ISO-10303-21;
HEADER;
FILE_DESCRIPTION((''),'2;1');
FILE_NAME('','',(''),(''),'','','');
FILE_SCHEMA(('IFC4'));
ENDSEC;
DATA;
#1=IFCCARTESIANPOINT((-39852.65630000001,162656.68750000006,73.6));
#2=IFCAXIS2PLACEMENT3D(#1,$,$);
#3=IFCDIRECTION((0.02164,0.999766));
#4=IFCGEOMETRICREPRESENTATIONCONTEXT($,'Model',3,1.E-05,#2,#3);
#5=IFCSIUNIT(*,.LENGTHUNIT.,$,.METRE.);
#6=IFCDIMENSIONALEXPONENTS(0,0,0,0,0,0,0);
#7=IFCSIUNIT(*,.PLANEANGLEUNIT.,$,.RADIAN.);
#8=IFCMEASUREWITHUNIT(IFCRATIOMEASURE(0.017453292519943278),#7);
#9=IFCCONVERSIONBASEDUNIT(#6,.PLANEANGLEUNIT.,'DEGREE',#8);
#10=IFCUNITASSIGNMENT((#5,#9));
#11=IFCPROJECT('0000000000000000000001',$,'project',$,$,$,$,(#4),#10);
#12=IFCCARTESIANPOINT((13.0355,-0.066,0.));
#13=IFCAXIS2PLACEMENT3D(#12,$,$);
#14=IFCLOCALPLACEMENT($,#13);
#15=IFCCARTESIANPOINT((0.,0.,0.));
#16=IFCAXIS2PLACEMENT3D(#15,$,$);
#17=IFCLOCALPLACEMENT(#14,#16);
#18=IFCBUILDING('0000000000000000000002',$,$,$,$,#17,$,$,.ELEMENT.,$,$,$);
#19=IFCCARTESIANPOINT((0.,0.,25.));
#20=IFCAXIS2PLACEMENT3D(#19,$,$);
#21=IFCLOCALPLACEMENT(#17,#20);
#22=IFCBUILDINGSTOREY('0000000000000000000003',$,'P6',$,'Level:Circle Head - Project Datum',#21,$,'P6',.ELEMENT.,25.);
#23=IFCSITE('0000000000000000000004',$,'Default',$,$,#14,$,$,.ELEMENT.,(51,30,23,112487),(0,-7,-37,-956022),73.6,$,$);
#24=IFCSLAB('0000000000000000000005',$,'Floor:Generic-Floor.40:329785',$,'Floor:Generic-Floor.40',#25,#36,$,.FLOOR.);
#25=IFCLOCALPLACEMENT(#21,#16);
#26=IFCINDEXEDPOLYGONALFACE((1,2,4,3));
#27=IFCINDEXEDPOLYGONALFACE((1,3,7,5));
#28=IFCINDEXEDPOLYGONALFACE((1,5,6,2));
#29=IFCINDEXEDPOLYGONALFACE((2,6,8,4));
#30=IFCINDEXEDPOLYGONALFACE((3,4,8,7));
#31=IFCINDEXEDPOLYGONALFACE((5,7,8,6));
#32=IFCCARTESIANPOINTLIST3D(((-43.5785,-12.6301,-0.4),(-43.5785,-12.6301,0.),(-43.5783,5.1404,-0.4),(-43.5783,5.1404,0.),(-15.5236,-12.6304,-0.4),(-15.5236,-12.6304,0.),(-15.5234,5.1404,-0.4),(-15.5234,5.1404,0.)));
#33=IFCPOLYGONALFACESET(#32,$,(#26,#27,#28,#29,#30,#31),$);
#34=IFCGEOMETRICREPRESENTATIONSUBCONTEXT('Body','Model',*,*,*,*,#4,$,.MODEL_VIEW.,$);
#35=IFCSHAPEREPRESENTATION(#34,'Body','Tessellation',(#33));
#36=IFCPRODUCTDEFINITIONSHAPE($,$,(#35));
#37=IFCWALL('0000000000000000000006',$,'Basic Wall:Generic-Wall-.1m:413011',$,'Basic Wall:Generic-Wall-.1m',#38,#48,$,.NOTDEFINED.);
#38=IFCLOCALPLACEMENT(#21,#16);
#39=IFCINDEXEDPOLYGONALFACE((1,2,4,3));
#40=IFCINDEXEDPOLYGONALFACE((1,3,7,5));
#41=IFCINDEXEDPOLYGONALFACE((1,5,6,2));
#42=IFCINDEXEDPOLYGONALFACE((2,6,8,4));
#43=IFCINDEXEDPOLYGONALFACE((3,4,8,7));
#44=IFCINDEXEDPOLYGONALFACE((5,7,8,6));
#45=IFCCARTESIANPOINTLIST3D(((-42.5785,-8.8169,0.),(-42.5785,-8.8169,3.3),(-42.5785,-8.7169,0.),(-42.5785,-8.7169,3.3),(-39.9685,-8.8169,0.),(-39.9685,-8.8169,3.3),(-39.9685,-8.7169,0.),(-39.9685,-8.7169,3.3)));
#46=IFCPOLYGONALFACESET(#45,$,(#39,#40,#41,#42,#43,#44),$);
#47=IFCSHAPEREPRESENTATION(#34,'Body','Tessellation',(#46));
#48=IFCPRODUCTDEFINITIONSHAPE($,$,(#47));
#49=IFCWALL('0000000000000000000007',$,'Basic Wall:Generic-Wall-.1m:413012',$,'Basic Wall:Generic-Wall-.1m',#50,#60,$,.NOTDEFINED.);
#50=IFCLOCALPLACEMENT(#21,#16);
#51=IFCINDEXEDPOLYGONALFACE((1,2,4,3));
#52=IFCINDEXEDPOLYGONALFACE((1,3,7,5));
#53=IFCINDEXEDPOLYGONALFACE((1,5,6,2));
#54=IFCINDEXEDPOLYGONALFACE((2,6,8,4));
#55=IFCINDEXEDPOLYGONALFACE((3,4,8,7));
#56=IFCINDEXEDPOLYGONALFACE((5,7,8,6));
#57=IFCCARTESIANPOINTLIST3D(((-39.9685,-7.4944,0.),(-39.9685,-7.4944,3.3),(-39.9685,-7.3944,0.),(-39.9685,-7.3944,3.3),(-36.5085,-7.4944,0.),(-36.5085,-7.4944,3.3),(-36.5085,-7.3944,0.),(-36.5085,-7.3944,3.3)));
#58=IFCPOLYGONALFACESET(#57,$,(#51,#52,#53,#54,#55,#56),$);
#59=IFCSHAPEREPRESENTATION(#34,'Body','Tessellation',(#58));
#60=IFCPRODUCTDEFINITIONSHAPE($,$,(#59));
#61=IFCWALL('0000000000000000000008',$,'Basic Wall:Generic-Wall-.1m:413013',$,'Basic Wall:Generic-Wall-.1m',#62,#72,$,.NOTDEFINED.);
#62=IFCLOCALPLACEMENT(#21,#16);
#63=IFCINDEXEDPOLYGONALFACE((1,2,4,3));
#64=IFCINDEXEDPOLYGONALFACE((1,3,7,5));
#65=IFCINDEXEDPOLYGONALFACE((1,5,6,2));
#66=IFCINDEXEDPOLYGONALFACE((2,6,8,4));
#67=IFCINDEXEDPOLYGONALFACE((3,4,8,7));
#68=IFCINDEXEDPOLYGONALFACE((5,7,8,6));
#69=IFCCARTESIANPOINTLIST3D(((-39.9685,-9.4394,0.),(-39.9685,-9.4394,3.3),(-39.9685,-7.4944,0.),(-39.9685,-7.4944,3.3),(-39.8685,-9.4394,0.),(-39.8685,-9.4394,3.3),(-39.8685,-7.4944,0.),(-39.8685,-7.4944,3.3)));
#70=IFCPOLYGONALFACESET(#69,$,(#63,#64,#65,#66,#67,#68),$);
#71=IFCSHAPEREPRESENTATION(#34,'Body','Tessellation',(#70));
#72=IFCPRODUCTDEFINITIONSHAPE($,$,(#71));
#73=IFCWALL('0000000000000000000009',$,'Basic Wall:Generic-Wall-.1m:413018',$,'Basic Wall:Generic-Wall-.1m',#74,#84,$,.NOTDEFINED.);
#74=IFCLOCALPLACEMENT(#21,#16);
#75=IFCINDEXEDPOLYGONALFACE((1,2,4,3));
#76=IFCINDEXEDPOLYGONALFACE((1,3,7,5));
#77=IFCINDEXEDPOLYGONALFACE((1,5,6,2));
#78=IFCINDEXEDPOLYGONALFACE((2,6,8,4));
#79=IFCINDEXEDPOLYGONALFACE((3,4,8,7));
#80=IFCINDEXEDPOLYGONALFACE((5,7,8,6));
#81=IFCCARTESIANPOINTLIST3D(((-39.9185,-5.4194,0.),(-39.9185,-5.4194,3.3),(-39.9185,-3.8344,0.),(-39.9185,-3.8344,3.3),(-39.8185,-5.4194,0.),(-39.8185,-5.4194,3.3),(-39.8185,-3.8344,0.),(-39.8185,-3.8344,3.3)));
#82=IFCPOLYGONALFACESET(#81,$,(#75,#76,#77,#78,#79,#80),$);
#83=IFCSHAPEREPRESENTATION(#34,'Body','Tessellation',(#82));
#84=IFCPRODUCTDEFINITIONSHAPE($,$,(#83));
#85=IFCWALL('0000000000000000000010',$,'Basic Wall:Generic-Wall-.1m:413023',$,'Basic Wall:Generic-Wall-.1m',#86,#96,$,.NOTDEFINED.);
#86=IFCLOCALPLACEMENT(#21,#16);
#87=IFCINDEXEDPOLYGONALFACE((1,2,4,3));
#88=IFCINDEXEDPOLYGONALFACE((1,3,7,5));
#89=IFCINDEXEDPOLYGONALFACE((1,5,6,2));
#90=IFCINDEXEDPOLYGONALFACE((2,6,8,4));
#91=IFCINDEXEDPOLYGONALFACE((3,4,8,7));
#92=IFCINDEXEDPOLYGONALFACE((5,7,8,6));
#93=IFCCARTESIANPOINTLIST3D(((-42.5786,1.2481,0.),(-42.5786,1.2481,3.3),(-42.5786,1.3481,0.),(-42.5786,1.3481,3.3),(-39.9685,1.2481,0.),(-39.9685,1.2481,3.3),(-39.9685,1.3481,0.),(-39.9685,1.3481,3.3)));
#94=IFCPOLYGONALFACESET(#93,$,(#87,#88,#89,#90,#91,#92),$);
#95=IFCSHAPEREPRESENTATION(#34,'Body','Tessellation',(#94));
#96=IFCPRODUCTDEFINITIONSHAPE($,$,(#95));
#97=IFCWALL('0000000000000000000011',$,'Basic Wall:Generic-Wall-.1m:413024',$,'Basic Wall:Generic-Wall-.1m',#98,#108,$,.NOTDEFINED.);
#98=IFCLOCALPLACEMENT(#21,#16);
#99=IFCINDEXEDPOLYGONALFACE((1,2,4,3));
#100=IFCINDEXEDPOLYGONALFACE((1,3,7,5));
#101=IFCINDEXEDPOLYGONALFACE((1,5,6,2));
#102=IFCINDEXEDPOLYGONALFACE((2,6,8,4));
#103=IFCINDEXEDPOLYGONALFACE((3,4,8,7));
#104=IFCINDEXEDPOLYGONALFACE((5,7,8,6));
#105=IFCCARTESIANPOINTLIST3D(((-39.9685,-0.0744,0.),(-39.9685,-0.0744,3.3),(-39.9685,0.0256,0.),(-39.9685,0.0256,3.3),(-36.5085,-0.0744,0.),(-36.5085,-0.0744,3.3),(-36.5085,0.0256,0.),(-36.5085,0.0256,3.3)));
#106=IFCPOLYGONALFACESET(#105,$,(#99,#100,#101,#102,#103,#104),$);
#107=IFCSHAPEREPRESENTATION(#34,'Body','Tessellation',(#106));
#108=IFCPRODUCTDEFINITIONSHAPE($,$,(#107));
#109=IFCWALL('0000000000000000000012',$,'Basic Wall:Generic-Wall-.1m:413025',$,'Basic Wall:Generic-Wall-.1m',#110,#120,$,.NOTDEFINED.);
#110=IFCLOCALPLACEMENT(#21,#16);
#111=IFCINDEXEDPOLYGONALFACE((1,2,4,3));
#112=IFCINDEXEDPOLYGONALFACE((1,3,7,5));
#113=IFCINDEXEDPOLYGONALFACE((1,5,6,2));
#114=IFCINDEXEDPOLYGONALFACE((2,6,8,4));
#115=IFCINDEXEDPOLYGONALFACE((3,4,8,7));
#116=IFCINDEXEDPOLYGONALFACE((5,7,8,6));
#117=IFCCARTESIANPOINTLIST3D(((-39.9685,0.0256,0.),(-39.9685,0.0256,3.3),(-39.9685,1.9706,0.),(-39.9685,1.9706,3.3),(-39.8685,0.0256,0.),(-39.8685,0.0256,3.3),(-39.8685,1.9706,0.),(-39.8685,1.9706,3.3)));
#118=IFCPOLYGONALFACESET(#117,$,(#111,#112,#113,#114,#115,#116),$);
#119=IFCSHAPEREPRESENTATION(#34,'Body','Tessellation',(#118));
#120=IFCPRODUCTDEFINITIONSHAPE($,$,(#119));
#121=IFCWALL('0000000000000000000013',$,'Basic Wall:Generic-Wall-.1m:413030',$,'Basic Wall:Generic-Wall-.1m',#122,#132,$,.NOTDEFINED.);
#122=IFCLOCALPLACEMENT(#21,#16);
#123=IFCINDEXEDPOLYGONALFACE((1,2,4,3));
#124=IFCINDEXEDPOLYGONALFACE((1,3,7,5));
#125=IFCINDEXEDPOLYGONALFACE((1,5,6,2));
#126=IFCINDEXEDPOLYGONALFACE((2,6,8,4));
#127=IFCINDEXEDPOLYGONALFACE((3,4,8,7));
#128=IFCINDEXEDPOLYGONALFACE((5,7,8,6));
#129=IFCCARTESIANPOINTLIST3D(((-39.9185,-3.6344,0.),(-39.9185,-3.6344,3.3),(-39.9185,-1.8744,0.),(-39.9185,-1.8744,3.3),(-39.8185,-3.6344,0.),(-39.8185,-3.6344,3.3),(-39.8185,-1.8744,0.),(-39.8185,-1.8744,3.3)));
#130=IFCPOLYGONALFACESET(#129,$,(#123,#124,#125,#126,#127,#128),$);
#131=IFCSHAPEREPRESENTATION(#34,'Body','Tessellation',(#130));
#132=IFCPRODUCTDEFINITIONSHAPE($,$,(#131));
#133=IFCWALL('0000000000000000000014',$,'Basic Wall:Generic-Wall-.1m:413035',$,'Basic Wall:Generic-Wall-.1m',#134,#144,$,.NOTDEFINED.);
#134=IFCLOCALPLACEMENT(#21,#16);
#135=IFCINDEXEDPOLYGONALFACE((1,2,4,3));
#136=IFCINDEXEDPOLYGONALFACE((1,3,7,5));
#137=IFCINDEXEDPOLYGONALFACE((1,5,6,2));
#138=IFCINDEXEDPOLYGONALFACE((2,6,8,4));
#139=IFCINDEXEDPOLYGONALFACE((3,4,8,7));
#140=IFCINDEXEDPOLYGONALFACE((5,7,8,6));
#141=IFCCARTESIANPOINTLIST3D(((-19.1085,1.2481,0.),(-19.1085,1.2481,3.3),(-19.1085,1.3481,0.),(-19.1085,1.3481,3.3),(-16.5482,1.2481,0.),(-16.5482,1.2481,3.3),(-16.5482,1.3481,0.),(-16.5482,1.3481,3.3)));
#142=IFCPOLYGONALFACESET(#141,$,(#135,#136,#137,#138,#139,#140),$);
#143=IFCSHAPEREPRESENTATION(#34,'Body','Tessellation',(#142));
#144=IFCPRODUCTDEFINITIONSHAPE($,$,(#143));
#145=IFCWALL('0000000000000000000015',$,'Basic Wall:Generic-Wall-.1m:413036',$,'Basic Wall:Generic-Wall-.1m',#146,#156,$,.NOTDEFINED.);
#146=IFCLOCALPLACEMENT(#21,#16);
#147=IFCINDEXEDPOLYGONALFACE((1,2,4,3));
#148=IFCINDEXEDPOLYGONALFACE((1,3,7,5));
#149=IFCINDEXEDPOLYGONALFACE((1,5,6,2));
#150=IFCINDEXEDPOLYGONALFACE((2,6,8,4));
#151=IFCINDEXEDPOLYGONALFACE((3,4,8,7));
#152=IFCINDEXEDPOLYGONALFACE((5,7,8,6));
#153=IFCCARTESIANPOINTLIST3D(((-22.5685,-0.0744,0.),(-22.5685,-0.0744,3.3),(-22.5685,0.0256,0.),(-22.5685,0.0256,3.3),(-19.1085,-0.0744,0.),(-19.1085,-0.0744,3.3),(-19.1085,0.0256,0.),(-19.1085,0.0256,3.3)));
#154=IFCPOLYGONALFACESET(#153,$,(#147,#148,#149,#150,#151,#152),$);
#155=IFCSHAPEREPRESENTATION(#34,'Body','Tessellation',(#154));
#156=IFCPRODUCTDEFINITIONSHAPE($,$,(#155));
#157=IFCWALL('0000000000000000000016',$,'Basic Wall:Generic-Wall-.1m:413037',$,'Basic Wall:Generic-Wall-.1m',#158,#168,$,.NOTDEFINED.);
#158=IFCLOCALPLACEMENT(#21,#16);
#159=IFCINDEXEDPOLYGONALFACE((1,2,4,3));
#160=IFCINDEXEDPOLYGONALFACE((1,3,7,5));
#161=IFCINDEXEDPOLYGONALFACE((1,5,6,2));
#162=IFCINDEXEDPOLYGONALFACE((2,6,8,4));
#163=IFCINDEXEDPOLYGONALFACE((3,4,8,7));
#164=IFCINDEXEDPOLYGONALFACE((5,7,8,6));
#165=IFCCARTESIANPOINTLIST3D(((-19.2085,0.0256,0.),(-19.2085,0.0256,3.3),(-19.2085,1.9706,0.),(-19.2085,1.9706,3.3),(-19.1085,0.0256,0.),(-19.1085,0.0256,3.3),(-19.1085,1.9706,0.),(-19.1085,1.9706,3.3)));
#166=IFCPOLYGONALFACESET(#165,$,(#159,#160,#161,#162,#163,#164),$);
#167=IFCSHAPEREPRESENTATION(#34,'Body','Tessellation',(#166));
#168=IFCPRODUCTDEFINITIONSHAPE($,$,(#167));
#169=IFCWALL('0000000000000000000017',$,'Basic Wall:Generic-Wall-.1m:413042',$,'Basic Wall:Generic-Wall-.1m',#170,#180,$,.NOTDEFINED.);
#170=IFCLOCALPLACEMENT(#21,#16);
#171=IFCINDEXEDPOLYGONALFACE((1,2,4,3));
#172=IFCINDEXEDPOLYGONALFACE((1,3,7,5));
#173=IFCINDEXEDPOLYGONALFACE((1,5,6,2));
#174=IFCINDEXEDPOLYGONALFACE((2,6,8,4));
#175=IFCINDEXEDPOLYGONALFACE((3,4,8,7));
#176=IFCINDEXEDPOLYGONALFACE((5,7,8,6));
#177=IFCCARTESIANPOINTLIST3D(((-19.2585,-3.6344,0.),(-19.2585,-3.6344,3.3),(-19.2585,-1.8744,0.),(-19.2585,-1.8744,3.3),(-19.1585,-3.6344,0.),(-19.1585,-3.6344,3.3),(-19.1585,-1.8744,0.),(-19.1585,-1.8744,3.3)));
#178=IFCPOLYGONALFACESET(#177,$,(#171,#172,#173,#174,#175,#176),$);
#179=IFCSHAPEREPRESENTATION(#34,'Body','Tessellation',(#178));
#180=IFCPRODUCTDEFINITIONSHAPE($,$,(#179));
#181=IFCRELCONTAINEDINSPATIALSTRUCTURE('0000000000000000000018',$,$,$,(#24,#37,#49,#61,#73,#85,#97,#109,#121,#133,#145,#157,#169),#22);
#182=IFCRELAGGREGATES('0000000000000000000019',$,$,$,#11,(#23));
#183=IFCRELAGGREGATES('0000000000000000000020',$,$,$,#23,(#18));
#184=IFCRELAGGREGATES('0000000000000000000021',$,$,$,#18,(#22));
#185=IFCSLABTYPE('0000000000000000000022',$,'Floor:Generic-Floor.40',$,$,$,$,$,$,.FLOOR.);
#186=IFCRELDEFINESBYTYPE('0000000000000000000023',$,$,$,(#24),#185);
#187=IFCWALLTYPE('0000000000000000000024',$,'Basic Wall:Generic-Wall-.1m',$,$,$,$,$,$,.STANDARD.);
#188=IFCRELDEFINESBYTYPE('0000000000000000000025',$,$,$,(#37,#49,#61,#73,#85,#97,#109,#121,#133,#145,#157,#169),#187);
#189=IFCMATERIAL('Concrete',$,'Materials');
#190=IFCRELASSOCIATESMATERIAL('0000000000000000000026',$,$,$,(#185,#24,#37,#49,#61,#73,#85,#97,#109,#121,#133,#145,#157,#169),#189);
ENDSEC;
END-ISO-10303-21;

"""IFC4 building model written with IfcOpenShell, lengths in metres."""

from ifc_helpers import new_model, entity, si_unit, converted_unit, direction, frame, origin, place, context, subcontext, project, spatial, indexed_curve, outline, extrude, material, type_object, element, save


model = new_model("IFC4")

# Units and contexts
model_context = context("Model", 3, precision=1e-05, world=frame((-39852.65630000001, 162656.68750000006, 73.6)), true_north=direction((0.02164, 0.999766)))
body_context = subcontext(model_context, "Body", "Model", "MODEL_VIEW")
ifc_project = project(units=[si_unit("LENGTHUNIT", "METRE"), converted_unit("PLANEANGLEUNIT", "DEGREE", entity("IfcRatioMeasure", 0.017453292519943278), si_unit("PLANEANGLEUNIT", "RADIAN"), dimensions=[0, 0, 0, 0, 0, 0, 0])], contexts=[model_context])

# Site, building, storey
site_placement = place(None, frame((13.0355, -0.066, 0.0)))
site = spatial("IfcSite", under=ifc_project, at=site_placement, Name="Default", CompositionType="ELEMENT", RefLatitude=(51, 30, 23, 112487), RefLongitude=(0, -7, -37, -956022), RefElevation=73.6)
building_placement = place(site_placement, origin())
building = spatial("IfcBuilding", under=site, at=building_placement, CompositionType="ELEMENT")
storey_placement = place(building_placement, frame((0.0, 0.0, 25.0)))
storey = spatial("IfcBuildingStorey", under=building, at=storey_placement, Name="P6", ObjectType="Level:Circle Head - Project Datum", LongName="P6", CompositionType="ELEMENT", Elevation=25.0)

# Shared definitions
ifc_material = material(Name="Concrete", Category="Materials")

# Slab
slab_type = type_object("IfcSlabType", Name="Floor:Generic-Floor.40", PredefinedType="FLOOR", material=ifc_material)
slab_placement = place(storey_placement, origin())
element("IfcSlab", 1, at=slab_placement, inside=storey, type_object=slab_type, material=ifc_material, Name="Floor:Generic-Floor.40:329785", ObjectType="Floor:Generic-Floor.40", PredefinedType="FLOOR", context=body_context, shape_type="SweptSolid", body=[
    extrude(outline(indexed_curve([(-14.0274, -8.8853), (14.0275, -8.8853), (14.0274, 8.8855), (-14.0275, 8.8852), (-14.0274, -8.8853)], self_intersect=False)), frame((-29.5509, -3.7449, 0.0), z_axis=(0.0, 0.0, -1.0), x_axis=(1.0, 0.0, 0.0)), (0.0, 0.0, 1.0), 0.4),
])

# Walls
wall_type = type_object("IfcWallType", Name="Basic Wall:Generic-Wall-.1m", PredefinedType="STANDARD")
wall_1_placement = place(storey_placement, frame((-39.9685, -8.7669, 0.0), z_axis=(0.0, 0.0, 1.0), x_axis=(-1.0, 0.0, 0.0)))
element("IfcWall", 2, at=wall_1_placement, inside=storey, type_object=wall_type, material=ifc_material, Name="Basic Wall:Generic-Wall-.1m:413011", ObjectType="Basic Wall:Generic-Wall-.1m", PredefinedType="NOTDEFINED", context=body_context, shape_type="SweptSolid", body=[
    extrude(outline(indexed_curve([(2.61, 0.05), (0.0, 0.05), (0.0, -0.05), (2.61, -0.05), (2.61, 0.05)], self_intersect=False)), origin(), (0.0, 0.0, 1.0), 3.3),
])
wall_2_placement = place(storey_placement, frame((-36.5085, -7.4444, 0.0), z_axis=(0.0, 0.0, 1.0), x_axis=(-1.0, 0.0, 0.0)))
element("IfcWall", 3, at=wall_2_placement, inside=storey, type_object=wall_type, material=ifc_material, Name="Basic Wall:Generic-Wall-.1m:413012", ObjectType="Basic Wall:Generic-Wall-.1m", PredefinedType="NOTDEFINED", context=body_context, shape_type="SweptSolid", body=[
    extrude(outline(indexed_curve([(3.46, 0.05), (0.0, 0.05), (0.0, -0.05), (3.46, -0.05), (3.46, 0.05)], self_intersect=False)), origin(), (0.0, 0.0, 1.0), 3.3),
])
wall_3_placement = place(storey_placement, frame((-39.9185, -7.4944, 0.0), z_axis=(0.0, 0.0, 1.0), x_axis=(0.0, -1.0, 0.0)))
element("IfcWall", 4, at=wall_3_placement, inside=storey, type_object=wall_type, material=ifc_material, Name="Basic Wall:Generic-Wall-.1m:413013", ObjectType="Basic Wall:Generic-Wall-.1m", PredefinedType="NOTDEFINED", context=body_context, shape_type="SweptSolid", body=[
    extrude(outline(indexed_curve([(1.945, 0.05), (0.0, 0.05), (0.0, -0.05), (1.945, -0.05), (1.945, 0.05)], self_intersect=False)), origin(), (0.0, 0.0, 1.0), 3.3),
])
wall_4_placement = place(storey_placement, frame((-39.8685, -5.4194, 0.0), z_axis=(0.0, 0.0, 1.0), x_axis=(0.0, 1.0, 0.0)))
element("IfcWall", 5, at=wall_4_placement, inside=storey, type_object=wall_type, material=ifc_material, Name="Basic Wall:Generic-Wall-.1m:413018", ObjectType="Basic Wall:Generic-Wall-.1m", PredefinedType="NOTDEFINED", context=body_context, shape_type="SweptSolid", body=[
    extrude(outline(indexed_curve([(1.585, 0.05), (0.0, 0.05), (0.0, -0.05), (1.585, -0.05), (1.585, 0.05)], self_intersect=False)), origin(), (0.0, 0.0, 1.0), 3.3),
])
wall_5_placement = place(storey_placement, frame((-39.9685, 1.2981, 0.0), z_axis=(0.0, 0.0, 1.0), x_axis=(-1.0, 0.0, 0.0)))
element("IfcWall", 6, at=wall_5_placement, inside=storey, type_object=wall_type, material=ifc_material, Name="Basic Wall:Generic-Wall-.1m:413023", ObjectType="Basic Wall:Generic-Wall-.1m", PredefinedType="NOTDEFINED", context=body_context, shape_type="SweptSolid", body=[
    extrude(outline(indexed_curve([(2.6101, 0.05), (0.0, 0.05), (0.0, -0.05), (2.6101, -0.05), (2.6101, 0.05)], self_intersect=False)), origin(), (0.0, 0.0, 1.0), 3.3),
])
wall_6_placement = place(storey_placement, frame((-36.5085, -0.0244, 0.0), z_axis=(0.0, 0.0, 1.0), x_axis=(-1.0, 0.0, 0.0)))
element("IfcWall", 7, at=wall_6_placement, inside=storey, type_object=wall_type, material=ifc_material, Name="Basic Wall:Generic-Wall-.1m:413024", ObjectType="Basic Wall:Generic-Wall-.1m", PredefinedType="NOTDEFINED", context=body_context, shape_type="SweptSolid", body=[
    extrude(outline(indexed_curve([(3.46, 0.05), (0.0, 0.05), (0.0, -0.05), (3.46, -0.05), (3.46, 0.05)], self_intersect=False)), origin(), (0.0, 0.0, 1.0), 3.3),
])
wall_7_placement = place(storey_placement, frame((-39.9185, 0.0256, 0.0), z_axis=(0.0, 0.0, 1.0), x_axis=(0.0, 1.0, 0.0)))
element("IfcWall", 8, at=wall_7_placement, inside=storey, type_object=wall_type, material=ifc_material, Name="Basic Wall:Generic-Wall-.1m:413025", ObjectType="Basic Wall:Generic-Wall-.1m", PredefinedType="NOTDEFINED", context=body_context, shape_type="SweptSolid", body=[
    extrude(outline(indexed_curve([(1.945, 0.05), (0.0, 0.05), (0.0, -0.05), (1.945, -0.05), (1.945, 0.05)], self_intersect=False)), origin(), (0.0, 0.0, 1.0), 3.3),
])
wall_8_placement = place(storey_placement, frame((-39.8685, -1.8744, 0.0), z_axis=(0.0, 0.0, 1.0), x_axis=(0.0, -1.0, 0.0)))
element("IfcWall", 9, at=wall_8_placement, inside=storey, type_object=wall_type, material=ifc_material, Name="Basic Wall:Generic-Wall-.1m:413030", ObjectType="Basic Wall:Generic-Wall-.1m", PredefinedType="NOTDEFINED", context=body_context, shape_type="SweptSolid", body=[
    extrude(outline(indexed_curve([(1.76, 0.05), (0.0, 0.05), (0.0, -0.05), (1.76, -0.05), (1.76, 0.05)], self_intersect=False)), origin(), (0.0, 0.0, 1.0), 3.3),
])
wall_9_placement = place(storey_placement, frame((-19.1085, 1.2981, 0.0)))
element("IfcWall", 10, at=wall_9_placement, inside=storey, type_object=wall_type, material=ifc_material, Name="Basic Wall:Generic-Wall-.1m:413035", ObjectType="Basic Wall:Generic-Wall-.1m", PredefinedType="NOTDEFINED", context=body_context, shape_type="SweptSolid", body=[
    extrude(outline(indexed_curve([(2.5602, 0.05), (0.0, 0.05), (0.0, -0.05), (2.5602, -0.05), (2.5602, 0.05)], self_intersect=False)), origin(), (0.0, 0.0, 1.0), 3.3),
])
wall_10_placement = place(storey_placement, frame((-22.5685, -0.0244, 0.0)))
element("IfcWall", 11, at=wall_10_placement, inside=storey, type_object=wall_type, material=ifc_material, Name="Basic Wall:Generic-Wall-.1m:413036", ObjectType="Basic Wall:Generic-Wall-.1m", PredefinedType="NOTDEFINED", context=body_context, shape_type="SweptSolid", body=[
    extrude(outline(indexed_curve([(3.46, 0.05), (0.0, 0.05), (0.0, -0.05), (3.46, -0.05), (3.46, 0.05)], self_intersect=False)), origin(), (0.0, 0.0, 1.0), 3.3),
])
wall_11_placement = place(storey_placement, frame((-19.1585, 0.0256, 0.0), z_axis=(0.0, 0.0, 1.0), x_axis=(0.0, 1.0, 0.0)))
element("IfcWall", 12, at=wall_11_placement, inside=storey, type_object=wall_type, material=ifc_material, Name="Basic Wall:Generic-Wall-.1m:413037", ObjectType="Basic Wall:Generic-Wall-.1m", PredefinedType="NOTDEFINED", context=body_context, shape_type="SweptSolid", body=[
    extrude(outline(indexed_curve([(1.945, 0.05), (0.0, 0.05), (0.0, -0.05), (1.945, -0.05), (1.945, 0.05)], self_intersect=False)), origin(), (0.0, 0.0, 1.0), 3.3),
])
wall_12_placement = place(storey_placement, frame((-19.2085, -1.8744, 0.0), z_axis=(0.0, 0.0, 1.0), x_axis=(0.0, -1.0, 0.0)))
element("IfcWall", 13, at=wall_12_placement, inside=storey, type_object=wall_type, material=ifc_material, Name="Basic Wall:Generic-Wall-.1m:413042", ObjectType="Basic Wall:Generic-Wall-.1m", PredefinedType="NOTDEFINED", context=body_context, shape_type="SweptSolid", body=[
    extrude(outline(indexed_curve([(1.76, 0.05), (0.0, 0.05), (0.0, -0.05), (1.76, -0.05), (1.76, 0.05)], self_intersect=False)), origin(), (0.0, 0.0, 1.0), 3.3),
])

save(model, "model.ifc")
